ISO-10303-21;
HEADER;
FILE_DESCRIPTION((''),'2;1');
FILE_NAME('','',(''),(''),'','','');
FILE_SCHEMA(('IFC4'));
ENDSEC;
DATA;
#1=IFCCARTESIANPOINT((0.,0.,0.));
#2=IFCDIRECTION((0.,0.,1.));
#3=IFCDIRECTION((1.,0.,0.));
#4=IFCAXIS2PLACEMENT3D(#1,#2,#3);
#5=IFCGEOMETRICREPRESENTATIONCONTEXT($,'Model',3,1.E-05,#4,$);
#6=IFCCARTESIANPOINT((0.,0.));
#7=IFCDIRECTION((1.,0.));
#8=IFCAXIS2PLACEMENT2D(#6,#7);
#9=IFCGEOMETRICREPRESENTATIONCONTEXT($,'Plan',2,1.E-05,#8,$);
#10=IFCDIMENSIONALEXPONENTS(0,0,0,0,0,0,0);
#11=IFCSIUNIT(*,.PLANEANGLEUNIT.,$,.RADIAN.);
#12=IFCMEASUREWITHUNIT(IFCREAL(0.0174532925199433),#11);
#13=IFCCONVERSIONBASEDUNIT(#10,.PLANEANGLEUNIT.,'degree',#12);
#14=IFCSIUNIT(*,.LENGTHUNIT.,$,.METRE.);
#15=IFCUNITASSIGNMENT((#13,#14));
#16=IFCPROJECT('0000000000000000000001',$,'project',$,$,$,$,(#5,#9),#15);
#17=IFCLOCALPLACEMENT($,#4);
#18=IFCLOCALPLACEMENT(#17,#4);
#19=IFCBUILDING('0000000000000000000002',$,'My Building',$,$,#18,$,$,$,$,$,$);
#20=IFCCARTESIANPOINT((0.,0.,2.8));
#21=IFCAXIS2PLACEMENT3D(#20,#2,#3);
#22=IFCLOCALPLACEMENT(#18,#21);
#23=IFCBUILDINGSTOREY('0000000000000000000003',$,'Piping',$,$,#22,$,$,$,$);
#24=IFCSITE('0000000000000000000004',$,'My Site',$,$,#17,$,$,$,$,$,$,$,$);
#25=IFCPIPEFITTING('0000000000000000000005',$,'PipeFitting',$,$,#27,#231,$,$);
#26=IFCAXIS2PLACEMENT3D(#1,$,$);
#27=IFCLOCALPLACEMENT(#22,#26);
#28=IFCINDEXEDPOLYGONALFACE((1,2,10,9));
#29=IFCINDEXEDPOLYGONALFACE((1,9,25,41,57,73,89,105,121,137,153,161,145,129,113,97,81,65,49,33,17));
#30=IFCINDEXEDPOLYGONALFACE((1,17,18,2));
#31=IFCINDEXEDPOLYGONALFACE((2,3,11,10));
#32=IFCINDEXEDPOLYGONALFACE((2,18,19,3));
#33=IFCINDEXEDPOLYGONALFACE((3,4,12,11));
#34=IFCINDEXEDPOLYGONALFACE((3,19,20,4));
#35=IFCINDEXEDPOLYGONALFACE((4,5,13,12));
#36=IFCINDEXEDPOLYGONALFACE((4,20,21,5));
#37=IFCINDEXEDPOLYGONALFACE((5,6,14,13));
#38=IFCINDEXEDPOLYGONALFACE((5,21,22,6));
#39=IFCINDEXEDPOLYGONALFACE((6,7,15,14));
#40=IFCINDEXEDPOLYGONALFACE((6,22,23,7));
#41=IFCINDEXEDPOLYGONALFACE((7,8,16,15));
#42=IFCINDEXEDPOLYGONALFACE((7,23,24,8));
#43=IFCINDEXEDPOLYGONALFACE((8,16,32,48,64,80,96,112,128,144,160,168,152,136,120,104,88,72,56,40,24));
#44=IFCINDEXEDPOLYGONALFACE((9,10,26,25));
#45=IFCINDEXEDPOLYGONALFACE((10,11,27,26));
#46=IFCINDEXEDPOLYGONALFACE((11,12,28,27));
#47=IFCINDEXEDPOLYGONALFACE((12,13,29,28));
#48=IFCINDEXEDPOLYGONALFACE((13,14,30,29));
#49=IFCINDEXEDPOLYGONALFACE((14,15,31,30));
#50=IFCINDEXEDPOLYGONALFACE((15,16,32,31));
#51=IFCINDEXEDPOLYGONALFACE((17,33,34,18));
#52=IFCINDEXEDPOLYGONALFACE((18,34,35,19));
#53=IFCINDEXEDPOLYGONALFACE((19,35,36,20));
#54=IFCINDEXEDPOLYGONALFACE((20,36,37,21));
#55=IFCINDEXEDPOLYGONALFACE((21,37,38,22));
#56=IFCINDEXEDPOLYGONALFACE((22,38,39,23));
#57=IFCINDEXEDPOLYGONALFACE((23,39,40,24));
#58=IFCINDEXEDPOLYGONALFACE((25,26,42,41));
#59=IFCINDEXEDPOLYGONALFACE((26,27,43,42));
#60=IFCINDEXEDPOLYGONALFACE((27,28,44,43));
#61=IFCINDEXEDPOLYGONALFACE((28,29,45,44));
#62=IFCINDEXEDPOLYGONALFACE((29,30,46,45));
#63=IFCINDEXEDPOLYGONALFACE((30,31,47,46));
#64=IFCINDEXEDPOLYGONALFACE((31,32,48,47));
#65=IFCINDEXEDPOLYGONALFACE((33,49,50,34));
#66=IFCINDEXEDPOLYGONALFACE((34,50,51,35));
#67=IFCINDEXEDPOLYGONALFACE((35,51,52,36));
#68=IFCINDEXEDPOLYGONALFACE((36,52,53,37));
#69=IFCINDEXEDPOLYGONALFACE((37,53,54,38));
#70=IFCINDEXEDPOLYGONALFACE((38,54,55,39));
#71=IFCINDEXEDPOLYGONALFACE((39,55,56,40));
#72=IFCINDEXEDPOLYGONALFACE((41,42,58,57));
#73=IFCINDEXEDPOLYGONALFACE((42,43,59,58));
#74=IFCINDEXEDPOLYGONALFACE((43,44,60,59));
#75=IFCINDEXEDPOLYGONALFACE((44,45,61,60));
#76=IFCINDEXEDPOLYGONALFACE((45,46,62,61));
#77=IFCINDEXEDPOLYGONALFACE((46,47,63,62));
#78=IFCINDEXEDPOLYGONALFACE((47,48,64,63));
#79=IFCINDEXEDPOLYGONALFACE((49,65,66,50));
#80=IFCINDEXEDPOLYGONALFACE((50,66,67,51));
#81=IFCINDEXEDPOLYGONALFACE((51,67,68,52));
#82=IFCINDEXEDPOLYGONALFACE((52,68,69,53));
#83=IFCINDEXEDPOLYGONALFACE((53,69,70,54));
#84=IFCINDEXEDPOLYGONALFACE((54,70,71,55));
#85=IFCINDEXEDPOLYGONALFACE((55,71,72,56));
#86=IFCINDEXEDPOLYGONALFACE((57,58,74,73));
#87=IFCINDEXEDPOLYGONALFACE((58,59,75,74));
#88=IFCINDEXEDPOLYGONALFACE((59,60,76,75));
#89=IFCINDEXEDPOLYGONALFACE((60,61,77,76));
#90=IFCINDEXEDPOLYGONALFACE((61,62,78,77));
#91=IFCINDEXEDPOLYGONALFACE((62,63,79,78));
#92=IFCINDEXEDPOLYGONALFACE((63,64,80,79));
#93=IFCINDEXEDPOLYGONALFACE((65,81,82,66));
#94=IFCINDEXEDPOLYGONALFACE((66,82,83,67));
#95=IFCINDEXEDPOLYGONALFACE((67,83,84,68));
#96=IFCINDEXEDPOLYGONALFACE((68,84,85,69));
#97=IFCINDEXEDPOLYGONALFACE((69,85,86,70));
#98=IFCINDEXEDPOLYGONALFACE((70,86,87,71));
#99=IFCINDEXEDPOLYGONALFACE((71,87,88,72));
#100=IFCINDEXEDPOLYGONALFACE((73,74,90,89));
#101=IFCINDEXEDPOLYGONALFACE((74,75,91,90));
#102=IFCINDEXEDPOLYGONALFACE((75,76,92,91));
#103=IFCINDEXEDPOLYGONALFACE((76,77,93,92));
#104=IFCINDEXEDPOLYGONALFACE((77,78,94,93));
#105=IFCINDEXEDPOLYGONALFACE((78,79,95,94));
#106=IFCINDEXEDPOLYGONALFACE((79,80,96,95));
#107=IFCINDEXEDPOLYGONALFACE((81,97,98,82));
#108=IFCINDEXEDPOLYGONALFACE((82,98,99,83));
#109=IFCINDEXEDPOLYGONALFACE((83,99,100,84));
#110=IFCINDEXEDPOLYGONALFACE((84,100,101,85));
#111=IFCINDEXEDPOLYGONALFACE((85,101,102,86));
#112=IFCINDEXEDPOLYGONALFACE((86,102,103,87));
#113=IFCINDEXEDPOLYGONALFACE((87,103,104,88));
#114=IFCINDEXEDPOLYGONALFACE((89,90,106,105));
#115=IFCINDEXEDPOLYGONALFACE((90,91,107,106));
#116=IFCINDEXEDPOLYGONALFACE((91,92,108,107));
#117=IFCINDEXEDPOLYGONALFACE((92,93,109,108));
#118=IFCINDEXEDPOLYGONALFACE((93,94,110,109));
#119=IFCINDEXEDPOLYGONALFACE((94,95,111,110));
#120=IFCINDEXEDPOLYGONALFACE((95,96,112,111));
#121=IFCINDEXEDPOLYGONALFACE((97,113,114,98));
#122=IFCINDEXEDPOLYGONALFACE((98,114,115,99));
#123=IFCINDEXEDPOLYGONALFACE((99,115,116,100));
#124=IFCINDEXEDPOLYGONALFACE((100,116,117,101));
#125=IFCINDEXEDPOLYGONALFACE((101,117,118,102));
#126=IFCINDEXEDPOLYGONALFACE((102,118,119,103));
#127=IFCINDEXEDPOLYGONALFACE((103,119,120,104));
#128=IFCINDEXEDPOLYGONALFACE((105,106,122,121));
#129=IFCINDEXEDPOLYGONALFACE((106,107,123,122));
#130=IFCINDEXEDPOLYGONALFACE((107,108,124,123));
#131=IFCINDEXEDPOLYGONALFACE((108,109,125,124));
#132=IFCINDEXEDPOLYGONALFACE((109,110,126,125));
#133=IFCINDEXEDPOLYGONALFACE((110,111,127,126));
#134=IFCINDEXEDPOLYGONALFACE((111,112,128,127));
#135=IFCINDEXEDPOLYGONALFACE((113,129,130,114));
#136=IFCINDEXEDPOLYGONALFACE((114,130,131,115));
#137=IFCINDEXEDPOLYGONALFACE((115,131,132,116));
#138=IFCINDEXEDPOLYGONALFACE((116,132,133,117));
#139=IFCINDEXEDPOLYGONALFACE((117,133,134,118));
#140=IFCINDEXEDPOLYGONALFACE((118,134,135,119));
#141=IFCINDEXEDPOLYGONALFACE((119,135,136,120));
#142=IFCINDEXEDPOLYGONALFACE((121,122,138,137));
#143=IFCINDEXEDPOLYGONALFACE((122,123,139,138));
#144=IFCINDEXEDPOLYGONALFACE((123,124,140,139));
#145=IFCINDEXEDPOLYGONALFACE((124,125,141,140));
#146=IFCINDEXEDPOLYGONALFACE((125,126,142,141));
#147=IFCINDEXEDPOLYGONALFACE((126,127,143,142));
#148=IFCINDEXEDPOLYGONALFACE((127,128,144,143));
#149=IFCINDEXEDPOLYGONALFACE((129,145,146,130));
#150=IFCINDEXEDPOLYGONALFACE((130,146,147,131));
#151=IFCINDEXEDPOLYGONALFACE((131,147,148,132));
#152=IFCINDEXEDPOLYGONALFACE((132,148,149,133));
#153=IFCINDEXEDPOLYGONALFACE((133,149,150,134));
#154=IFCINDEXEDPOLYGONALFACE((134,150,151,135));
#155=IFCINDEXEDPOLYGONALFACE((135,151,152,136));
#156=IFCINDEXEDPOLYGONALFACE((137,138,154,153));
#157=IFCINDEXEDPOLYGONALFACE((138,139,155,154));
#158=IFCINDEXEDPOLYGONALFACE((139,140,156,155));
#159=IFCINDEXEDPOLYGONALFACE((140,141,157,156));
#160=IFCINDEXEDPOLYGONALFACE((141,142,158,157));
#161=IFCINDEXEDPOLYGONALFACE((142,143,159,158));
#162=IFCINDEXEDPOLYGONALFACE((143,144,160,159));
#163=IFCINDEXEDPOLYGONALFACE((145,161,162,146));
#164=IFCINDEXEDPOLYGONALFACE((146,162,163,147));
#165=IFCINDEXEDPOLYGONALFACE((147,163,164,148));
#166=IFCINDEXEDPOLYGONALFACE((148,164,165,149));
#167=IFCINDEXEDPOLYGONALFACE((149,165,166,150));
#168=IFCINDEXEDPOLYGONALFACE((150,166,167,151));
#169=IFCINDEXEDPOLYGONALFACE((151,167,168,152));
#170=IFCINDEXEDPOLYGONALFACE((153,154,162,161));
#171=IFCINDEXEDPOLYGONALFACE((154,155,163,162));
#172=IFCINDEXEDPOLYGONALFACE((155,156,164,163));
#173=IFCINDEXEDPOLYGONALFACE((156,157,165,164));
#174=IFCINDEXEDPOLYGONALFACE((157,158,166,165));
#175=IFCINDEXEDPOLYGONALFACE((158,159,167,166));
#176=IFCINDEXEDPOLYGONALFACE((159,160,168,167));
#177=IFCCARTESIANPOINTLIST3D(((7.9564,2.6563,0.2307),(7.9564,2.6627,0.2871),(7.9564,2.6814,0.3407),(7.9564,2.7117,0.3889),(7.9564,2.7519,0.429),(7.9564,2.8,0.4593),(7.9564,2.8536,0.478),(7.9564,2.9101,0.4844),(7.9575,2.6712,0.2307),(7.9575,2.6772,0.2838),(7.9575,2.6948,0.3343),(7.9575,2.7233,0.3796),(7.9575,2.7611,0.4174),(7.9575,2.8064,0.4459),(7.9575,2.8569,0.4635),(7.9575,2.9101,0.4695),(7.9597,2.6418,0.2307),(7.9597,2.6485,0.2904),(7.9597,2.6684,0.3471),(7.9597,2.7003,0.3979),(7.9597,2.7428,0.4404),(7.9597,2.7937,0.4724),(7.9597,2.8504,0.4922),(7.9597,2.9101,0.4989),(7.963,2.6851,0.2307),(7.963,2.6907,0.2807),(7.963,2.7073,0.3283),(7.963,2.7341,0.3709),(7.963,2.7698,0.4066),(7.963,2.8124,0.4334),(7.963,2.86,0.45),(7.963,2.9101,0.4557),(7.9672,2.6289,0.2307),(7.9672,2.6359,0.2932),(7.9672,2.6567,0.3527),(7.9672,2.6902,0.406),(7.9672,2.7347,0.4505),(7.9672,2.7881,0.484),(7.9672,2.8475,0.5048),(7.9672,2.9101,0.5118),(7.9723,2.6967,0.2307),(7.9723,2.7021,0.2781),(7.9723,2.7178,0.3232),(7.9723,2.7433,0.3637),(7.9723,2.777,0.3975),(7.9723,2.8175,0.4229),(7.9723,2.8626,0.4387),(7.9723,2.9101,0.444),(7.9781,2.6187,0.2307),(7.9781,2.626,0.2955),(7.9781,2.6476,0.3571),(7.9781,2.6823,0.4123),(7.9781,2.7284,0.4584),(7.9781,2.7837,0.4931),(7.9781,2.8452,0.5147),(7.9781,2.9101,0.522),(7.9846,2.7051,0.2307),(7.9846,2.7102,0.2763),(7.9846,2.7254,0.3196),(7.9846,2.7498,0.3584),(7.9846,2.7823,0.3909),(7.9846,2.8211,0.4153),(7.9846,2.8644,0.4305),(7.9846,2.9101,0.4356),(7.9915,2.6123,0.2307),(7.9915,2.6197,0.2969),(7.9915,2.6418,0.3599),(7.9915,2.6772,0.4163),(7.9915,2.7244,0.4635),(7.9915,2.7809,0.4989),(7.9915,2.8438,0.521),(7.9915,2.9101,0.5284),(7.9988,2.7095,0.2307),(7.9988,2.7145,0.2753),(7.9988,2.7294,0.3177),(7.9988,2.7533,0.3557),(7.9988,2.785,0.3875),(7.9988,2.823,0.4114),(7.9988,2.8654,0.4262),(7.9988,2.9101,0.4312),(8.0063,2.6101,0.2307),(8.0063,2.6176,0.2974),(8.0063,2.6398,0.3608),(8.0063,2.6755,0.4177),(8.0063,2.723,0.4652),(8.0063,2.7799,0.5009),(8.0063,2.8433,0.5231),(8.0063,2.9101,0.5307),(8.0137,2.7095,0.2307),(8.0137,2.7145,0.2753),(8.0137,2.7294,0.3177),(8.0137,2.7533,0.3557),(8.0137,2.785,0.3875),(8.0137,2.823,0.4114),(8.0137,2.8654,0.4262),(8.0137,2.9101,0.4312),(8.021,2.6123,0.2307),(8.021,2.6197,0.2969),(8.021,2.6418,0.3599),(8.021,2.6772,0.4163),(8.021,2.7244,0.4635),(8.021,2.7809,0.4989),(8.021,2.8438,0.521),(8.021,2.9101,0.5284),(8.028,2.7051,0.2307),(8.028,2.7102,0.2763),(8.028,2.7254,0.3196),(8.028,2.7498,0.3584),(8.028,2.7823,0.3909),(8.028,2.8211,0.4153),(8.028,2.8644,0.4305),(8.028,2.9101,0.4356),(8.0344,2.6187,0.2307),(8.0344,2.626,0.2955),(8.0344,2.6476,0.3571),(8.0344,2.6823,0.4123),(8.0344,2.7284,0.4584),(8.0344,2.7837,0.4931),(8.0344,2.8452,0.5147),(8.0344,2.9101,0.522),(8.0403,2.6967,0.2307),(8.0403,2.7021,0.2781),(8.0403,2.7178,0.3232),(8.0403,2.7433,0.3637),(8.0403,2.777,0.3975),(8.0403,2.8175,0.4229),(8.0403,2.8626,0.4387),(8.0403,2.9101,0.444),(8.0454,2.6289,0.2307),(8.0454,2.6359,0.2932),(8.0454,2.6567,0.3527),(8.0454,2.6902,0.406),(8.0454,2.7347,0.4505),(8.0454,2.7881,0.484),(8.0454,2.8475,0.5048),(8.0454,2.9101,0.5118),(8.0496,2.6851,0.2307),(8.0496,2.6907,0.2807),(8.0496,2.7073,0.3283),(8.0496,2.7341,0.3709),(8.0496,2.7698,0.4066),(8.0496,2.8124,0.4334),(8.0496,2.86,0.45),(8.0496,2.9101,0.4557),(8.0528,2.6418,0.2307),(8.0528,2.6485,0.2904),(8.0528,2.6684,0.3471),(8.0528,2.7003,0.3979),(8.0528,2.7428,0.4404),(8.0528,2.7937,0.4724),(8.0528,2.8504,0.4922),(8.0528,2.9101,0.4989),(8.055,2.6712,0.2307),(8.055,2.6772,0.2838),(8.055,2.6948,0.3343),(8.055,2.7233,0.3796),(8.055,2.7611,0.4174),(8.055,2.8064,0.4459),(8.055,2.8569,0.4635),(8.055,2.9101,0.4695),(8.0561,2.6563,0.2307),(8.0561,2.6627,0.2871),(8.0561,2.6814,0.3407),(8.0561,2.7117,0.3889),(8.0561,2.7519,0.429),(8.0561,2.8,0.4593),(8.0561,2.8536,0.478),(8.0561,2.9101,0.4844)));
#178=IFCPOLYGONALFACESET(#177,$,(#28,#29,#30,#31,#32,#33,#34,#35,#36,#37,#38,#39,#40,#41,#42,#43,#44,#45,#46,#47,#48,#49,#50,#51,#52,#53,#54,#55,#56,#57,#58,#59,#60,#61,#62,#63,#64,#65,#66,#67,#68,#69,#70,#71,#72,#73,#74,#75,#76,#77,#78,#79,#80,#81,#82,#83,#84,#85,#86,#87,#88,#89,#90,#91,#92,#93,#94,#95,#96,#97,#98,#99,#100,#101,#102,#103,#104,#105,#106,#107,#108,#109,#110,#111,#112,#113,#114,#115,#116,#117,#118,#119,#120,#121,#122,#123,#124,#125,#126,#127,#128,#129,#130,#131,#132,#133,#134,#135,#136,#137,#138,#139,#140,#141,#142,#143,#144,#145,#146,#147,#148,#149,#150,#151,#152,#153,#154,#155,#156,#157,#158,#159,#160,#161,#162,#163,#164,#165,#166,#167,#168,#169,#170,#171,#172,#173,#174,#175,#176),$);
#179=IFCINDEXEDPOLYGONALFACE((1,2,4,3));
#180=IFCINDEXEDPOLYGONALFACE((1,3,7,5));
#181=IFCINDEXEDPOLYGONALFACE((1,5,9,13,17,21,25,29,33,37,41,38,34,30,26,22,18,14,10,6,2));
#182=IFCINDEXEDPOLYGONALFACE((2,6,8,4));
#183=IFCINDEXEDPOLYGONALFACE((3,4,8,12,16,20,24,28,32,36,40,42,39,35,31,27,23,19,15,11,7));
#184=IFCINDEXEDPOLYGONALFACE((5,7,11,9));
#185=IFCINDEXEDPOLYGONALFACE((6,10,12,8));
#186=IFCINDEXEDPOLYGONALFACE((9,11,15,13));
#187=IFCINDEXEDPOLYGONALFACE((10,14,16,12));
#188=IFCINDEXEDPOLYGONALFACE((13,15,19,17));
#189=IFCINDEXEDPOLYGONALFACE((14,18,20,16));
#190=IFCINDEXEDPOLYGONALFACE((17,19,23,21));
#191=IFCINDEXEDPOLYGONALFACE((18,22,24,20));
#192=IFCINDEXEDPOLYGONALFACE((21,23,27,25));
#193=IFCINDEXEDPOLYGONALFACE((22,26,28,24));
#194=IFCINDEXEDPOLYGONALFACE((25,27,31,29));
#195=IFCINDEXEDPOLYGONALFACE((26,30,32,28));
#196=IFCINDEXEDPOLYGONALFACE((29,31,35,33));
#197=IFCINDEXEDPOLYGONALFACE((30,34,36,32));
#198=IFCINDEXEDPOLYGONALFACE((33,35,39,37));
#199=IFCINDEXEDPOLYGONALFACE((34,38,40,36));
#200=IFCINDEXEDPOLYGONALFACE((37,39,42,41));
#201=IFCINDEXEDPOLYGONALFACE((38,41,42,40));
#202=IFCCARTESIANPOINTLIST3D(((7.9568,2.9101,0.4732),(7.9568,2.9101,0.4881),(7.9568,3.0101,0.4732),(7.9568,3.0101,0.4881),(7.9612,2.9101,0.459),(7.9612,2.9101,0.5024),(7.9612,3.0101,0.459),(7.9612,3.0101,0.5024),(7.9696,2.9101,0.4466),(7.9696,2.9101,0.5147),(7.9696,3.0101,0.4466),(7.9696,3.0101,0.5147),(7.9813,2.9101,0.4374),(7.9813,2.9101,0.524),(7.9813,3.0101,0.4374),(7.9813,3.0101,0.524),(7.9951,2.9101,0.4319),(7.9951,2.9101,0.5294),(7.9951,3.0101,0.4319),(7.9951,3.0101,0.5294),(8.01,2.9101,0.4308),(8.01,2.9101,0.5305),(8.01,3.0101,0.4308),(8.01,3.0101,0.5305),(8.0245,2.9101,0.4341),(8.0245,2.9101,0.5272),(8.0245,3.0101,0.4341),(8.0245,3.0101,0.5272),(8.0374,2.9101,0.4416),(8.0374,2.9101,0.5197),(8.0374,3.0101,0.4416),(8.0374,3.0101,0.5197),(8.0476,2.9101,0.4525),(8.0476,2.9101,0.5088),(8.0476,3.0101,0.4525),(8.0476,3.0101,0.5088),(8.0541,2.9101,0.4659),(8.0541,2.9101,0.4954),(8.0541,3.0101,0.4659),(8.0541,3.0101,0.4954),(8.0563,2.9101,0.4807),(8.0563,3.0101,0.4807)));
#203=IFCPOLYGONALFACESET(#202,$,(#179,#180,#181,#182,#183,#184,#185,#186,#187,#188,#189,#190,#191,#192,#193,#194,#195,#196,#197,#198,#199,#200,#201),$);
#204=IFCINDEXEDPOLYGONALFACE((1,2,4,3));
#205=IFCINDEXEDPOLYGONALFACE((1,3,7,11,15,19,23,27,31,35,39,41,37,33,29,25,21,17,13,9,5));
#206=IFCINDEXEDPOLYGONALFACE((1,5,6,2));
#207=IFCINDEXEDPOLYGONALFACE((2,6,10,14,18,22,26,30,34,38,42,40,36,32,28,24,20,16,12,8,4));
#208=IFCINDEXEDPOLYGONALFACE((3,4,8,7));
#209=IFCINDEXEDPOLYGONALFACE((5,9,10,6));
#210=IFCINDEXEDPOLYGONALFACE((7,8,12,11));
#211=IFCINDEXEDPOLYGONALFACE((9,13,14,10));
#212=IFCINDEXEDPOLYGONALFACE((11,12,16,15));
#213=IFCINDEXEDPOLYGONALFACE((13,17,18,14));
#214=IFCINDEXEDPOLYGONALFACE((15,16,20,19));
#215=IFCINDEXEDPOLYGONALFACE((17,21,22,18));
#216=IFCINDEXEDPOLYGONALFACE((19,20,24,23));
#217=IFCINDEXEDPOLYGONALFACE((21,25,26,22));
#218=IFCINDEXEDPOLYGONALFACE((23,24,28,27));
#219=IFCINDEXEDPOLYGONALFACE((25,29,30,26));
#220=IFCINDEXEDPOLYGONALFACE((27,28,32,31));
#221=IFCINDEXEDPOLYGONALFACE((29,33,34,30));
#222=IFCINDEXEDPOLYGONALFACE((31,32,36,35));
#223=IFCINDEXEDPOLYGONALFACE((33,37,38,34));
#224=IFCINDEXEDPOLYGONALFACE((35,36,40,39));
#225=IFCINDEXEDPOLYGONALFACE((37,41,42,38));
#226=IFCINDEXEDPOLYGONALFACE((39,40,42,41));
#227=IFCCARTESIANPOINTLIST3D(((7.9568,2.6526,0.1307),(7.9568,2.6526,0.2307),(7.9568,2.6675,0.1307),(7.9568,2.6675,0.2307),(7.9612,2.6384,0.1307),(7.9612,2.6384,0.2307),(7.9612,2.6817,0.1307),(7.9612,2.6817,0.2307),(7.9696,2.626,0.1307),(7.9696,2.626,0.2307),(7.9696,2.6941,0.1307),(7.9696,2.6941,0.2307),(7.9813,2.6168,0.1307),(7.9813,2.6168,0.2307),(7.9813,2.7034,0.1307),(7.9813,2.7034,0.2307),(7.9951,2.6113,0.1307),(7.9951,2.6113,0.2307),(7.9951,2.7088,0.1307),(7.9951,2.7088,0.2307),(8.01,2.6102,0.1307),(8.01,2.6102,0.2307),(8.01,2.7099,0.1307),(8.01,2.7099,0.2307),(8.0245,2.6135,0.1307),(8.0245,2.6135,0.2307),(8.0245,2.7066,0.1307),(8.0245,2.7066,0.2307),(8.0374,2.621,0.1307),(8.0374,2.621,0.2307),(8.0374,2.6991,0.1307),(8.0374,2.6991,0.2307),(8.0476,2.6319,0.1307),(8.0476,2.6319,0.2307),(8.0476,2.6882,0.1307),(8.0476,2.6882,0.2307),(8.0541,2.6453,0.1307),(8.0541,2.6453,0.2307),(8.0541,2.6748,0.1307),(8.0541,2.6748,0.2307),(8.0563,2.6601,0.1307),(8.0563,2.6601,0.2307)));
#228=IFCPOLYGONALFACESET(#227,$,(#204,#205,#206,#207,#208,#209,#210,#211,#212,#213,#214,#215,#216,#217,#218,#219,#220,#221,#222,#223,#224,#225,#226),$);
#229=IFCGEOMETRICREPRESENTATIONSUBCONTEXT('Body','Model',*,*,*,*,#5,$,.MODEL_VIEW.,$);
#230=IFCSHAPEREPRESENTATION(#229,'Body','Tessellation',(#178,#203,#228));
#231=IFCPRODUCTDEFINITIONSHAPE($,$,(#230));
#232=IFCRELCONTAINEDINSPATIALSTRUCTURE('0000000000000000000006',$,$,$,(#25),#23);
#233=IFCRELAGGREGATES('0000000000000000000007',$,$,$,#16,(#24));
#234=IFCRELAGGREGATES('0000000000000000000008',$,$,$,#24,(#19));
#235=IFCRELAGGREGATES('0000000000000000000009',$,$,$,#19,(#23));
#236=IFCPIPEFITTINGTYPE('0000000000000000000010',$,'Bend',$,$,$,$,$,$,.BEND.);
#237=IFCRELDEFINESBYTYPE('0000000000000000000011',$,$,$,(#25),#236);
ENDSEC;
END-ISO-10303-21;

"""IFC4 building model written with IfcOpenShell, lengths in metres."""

from ifc_helpers import new_model, entity, si_unit, converted_unit, frame, origin_with_axes, origin_2d_with_axis, place, context, subcontext, project, spatial, circle, extrude, source, transform, mapped, type_object, type_shapes, element, save


model = new_model("IFC4")

# Units and contexts
model_context = context("Model", 3, precision=1e-05, world=origin_with_axes())
plan_context = context("Plan", 2, precision=1e-05, world=origin_2d_with_axis())
body_context = subcontext(model_context, "Body", "Model", "MODEL_VIEW")
ifc_project = project(units=[converted_unit("PLANEANGLEUNIT", "degree", entity("IfcReal", 0.0174532925199433), si_unit("PLANEANGLEUNIT", "RADIAN"), dimensions=[0, 0, 0, 0, 0, 0, 0]), si_unit("LENGTHUNIT", "METRE")], contexts=[model_context, plan_context])

# Site, building, storey
site_placement = place(None, origin_with_axes())
site = spatial("IfcSite", under=ifc_project, at=site_placement, Name="My Site")
building_placement = place(site_placement, origin_with_axes())
building = spatial("IfcBuilding", under=site, at=building_placement, Name="My Building")
storey_placement = place(building_placement, frame((0.0, 0.0, 2.8), z_axis=(0.0, 0.0, 1.0), x_axis=(1.0, 0.0, 0.0)))
storey = spatial("IfcBuildingStorey", under=building, at=storey_placement, Name="Piping")

# Pipe fitting
pipe_fitting_type_1 = type_object("IfcPipeFittingType", Name="Bend", PredefinedType="BEND")
shared_shape_1 = source(origin_with_axes(), body_context, "Body", "SolidModel", [
    entity("IfcSweptDiskSolid", entity("IfcIndexedPolyCurve", entity("IfcCartesianPointList3D", [[0.0, 0.0, 0.1], [0.0, -0.0732, 0.2768], [0.0, -0.25, 0.35]]), [entity("IfcArcIndex", [1, 2, 3])]), 0.05),
    extrude(circle(Radius=0.05), origin_with_axes(), (0.0, 0.0, 1.0), 0.1),
    extrude(circle(Radius=0.05), frame((0.0, -0.25, 0.35), z_axis=(0.0, -1.0, 0.0), x_axis=(1.0, 0.0, 0.0)), (0.0, 0.0, 1.0), 0.1),
])
type_shapes(pipe_fitting_type_1, [shared_shape_1])
for number, where, z_axis, x_axis, name in (
    (1, (8.0063, 3.0101, 0.4807), (0.0, -1.0, 0.0), (1.0, 0.0, 0.0), "PipeFitting"),
):
    element("IfcPipeFitting", number, at=place(storey_placement, frame(where, z_axis=z_axis, x_axis=x_axis)), inside=storey, type_object=pipe_fitting_type_1, Name=name, context=body_context, shape_type="MappedRepresentation", body=[
        mapped(shared_shape_1, transform((0.0, 0.0, 0.0), x_axis=(1.0, 0.0, 0.0), y_axis=(0.0, 1.0, 0.0), z_axis=(0.0, 0.0, 1.0), scale=1.0)),
    ])

save(model, "model.ifc")
